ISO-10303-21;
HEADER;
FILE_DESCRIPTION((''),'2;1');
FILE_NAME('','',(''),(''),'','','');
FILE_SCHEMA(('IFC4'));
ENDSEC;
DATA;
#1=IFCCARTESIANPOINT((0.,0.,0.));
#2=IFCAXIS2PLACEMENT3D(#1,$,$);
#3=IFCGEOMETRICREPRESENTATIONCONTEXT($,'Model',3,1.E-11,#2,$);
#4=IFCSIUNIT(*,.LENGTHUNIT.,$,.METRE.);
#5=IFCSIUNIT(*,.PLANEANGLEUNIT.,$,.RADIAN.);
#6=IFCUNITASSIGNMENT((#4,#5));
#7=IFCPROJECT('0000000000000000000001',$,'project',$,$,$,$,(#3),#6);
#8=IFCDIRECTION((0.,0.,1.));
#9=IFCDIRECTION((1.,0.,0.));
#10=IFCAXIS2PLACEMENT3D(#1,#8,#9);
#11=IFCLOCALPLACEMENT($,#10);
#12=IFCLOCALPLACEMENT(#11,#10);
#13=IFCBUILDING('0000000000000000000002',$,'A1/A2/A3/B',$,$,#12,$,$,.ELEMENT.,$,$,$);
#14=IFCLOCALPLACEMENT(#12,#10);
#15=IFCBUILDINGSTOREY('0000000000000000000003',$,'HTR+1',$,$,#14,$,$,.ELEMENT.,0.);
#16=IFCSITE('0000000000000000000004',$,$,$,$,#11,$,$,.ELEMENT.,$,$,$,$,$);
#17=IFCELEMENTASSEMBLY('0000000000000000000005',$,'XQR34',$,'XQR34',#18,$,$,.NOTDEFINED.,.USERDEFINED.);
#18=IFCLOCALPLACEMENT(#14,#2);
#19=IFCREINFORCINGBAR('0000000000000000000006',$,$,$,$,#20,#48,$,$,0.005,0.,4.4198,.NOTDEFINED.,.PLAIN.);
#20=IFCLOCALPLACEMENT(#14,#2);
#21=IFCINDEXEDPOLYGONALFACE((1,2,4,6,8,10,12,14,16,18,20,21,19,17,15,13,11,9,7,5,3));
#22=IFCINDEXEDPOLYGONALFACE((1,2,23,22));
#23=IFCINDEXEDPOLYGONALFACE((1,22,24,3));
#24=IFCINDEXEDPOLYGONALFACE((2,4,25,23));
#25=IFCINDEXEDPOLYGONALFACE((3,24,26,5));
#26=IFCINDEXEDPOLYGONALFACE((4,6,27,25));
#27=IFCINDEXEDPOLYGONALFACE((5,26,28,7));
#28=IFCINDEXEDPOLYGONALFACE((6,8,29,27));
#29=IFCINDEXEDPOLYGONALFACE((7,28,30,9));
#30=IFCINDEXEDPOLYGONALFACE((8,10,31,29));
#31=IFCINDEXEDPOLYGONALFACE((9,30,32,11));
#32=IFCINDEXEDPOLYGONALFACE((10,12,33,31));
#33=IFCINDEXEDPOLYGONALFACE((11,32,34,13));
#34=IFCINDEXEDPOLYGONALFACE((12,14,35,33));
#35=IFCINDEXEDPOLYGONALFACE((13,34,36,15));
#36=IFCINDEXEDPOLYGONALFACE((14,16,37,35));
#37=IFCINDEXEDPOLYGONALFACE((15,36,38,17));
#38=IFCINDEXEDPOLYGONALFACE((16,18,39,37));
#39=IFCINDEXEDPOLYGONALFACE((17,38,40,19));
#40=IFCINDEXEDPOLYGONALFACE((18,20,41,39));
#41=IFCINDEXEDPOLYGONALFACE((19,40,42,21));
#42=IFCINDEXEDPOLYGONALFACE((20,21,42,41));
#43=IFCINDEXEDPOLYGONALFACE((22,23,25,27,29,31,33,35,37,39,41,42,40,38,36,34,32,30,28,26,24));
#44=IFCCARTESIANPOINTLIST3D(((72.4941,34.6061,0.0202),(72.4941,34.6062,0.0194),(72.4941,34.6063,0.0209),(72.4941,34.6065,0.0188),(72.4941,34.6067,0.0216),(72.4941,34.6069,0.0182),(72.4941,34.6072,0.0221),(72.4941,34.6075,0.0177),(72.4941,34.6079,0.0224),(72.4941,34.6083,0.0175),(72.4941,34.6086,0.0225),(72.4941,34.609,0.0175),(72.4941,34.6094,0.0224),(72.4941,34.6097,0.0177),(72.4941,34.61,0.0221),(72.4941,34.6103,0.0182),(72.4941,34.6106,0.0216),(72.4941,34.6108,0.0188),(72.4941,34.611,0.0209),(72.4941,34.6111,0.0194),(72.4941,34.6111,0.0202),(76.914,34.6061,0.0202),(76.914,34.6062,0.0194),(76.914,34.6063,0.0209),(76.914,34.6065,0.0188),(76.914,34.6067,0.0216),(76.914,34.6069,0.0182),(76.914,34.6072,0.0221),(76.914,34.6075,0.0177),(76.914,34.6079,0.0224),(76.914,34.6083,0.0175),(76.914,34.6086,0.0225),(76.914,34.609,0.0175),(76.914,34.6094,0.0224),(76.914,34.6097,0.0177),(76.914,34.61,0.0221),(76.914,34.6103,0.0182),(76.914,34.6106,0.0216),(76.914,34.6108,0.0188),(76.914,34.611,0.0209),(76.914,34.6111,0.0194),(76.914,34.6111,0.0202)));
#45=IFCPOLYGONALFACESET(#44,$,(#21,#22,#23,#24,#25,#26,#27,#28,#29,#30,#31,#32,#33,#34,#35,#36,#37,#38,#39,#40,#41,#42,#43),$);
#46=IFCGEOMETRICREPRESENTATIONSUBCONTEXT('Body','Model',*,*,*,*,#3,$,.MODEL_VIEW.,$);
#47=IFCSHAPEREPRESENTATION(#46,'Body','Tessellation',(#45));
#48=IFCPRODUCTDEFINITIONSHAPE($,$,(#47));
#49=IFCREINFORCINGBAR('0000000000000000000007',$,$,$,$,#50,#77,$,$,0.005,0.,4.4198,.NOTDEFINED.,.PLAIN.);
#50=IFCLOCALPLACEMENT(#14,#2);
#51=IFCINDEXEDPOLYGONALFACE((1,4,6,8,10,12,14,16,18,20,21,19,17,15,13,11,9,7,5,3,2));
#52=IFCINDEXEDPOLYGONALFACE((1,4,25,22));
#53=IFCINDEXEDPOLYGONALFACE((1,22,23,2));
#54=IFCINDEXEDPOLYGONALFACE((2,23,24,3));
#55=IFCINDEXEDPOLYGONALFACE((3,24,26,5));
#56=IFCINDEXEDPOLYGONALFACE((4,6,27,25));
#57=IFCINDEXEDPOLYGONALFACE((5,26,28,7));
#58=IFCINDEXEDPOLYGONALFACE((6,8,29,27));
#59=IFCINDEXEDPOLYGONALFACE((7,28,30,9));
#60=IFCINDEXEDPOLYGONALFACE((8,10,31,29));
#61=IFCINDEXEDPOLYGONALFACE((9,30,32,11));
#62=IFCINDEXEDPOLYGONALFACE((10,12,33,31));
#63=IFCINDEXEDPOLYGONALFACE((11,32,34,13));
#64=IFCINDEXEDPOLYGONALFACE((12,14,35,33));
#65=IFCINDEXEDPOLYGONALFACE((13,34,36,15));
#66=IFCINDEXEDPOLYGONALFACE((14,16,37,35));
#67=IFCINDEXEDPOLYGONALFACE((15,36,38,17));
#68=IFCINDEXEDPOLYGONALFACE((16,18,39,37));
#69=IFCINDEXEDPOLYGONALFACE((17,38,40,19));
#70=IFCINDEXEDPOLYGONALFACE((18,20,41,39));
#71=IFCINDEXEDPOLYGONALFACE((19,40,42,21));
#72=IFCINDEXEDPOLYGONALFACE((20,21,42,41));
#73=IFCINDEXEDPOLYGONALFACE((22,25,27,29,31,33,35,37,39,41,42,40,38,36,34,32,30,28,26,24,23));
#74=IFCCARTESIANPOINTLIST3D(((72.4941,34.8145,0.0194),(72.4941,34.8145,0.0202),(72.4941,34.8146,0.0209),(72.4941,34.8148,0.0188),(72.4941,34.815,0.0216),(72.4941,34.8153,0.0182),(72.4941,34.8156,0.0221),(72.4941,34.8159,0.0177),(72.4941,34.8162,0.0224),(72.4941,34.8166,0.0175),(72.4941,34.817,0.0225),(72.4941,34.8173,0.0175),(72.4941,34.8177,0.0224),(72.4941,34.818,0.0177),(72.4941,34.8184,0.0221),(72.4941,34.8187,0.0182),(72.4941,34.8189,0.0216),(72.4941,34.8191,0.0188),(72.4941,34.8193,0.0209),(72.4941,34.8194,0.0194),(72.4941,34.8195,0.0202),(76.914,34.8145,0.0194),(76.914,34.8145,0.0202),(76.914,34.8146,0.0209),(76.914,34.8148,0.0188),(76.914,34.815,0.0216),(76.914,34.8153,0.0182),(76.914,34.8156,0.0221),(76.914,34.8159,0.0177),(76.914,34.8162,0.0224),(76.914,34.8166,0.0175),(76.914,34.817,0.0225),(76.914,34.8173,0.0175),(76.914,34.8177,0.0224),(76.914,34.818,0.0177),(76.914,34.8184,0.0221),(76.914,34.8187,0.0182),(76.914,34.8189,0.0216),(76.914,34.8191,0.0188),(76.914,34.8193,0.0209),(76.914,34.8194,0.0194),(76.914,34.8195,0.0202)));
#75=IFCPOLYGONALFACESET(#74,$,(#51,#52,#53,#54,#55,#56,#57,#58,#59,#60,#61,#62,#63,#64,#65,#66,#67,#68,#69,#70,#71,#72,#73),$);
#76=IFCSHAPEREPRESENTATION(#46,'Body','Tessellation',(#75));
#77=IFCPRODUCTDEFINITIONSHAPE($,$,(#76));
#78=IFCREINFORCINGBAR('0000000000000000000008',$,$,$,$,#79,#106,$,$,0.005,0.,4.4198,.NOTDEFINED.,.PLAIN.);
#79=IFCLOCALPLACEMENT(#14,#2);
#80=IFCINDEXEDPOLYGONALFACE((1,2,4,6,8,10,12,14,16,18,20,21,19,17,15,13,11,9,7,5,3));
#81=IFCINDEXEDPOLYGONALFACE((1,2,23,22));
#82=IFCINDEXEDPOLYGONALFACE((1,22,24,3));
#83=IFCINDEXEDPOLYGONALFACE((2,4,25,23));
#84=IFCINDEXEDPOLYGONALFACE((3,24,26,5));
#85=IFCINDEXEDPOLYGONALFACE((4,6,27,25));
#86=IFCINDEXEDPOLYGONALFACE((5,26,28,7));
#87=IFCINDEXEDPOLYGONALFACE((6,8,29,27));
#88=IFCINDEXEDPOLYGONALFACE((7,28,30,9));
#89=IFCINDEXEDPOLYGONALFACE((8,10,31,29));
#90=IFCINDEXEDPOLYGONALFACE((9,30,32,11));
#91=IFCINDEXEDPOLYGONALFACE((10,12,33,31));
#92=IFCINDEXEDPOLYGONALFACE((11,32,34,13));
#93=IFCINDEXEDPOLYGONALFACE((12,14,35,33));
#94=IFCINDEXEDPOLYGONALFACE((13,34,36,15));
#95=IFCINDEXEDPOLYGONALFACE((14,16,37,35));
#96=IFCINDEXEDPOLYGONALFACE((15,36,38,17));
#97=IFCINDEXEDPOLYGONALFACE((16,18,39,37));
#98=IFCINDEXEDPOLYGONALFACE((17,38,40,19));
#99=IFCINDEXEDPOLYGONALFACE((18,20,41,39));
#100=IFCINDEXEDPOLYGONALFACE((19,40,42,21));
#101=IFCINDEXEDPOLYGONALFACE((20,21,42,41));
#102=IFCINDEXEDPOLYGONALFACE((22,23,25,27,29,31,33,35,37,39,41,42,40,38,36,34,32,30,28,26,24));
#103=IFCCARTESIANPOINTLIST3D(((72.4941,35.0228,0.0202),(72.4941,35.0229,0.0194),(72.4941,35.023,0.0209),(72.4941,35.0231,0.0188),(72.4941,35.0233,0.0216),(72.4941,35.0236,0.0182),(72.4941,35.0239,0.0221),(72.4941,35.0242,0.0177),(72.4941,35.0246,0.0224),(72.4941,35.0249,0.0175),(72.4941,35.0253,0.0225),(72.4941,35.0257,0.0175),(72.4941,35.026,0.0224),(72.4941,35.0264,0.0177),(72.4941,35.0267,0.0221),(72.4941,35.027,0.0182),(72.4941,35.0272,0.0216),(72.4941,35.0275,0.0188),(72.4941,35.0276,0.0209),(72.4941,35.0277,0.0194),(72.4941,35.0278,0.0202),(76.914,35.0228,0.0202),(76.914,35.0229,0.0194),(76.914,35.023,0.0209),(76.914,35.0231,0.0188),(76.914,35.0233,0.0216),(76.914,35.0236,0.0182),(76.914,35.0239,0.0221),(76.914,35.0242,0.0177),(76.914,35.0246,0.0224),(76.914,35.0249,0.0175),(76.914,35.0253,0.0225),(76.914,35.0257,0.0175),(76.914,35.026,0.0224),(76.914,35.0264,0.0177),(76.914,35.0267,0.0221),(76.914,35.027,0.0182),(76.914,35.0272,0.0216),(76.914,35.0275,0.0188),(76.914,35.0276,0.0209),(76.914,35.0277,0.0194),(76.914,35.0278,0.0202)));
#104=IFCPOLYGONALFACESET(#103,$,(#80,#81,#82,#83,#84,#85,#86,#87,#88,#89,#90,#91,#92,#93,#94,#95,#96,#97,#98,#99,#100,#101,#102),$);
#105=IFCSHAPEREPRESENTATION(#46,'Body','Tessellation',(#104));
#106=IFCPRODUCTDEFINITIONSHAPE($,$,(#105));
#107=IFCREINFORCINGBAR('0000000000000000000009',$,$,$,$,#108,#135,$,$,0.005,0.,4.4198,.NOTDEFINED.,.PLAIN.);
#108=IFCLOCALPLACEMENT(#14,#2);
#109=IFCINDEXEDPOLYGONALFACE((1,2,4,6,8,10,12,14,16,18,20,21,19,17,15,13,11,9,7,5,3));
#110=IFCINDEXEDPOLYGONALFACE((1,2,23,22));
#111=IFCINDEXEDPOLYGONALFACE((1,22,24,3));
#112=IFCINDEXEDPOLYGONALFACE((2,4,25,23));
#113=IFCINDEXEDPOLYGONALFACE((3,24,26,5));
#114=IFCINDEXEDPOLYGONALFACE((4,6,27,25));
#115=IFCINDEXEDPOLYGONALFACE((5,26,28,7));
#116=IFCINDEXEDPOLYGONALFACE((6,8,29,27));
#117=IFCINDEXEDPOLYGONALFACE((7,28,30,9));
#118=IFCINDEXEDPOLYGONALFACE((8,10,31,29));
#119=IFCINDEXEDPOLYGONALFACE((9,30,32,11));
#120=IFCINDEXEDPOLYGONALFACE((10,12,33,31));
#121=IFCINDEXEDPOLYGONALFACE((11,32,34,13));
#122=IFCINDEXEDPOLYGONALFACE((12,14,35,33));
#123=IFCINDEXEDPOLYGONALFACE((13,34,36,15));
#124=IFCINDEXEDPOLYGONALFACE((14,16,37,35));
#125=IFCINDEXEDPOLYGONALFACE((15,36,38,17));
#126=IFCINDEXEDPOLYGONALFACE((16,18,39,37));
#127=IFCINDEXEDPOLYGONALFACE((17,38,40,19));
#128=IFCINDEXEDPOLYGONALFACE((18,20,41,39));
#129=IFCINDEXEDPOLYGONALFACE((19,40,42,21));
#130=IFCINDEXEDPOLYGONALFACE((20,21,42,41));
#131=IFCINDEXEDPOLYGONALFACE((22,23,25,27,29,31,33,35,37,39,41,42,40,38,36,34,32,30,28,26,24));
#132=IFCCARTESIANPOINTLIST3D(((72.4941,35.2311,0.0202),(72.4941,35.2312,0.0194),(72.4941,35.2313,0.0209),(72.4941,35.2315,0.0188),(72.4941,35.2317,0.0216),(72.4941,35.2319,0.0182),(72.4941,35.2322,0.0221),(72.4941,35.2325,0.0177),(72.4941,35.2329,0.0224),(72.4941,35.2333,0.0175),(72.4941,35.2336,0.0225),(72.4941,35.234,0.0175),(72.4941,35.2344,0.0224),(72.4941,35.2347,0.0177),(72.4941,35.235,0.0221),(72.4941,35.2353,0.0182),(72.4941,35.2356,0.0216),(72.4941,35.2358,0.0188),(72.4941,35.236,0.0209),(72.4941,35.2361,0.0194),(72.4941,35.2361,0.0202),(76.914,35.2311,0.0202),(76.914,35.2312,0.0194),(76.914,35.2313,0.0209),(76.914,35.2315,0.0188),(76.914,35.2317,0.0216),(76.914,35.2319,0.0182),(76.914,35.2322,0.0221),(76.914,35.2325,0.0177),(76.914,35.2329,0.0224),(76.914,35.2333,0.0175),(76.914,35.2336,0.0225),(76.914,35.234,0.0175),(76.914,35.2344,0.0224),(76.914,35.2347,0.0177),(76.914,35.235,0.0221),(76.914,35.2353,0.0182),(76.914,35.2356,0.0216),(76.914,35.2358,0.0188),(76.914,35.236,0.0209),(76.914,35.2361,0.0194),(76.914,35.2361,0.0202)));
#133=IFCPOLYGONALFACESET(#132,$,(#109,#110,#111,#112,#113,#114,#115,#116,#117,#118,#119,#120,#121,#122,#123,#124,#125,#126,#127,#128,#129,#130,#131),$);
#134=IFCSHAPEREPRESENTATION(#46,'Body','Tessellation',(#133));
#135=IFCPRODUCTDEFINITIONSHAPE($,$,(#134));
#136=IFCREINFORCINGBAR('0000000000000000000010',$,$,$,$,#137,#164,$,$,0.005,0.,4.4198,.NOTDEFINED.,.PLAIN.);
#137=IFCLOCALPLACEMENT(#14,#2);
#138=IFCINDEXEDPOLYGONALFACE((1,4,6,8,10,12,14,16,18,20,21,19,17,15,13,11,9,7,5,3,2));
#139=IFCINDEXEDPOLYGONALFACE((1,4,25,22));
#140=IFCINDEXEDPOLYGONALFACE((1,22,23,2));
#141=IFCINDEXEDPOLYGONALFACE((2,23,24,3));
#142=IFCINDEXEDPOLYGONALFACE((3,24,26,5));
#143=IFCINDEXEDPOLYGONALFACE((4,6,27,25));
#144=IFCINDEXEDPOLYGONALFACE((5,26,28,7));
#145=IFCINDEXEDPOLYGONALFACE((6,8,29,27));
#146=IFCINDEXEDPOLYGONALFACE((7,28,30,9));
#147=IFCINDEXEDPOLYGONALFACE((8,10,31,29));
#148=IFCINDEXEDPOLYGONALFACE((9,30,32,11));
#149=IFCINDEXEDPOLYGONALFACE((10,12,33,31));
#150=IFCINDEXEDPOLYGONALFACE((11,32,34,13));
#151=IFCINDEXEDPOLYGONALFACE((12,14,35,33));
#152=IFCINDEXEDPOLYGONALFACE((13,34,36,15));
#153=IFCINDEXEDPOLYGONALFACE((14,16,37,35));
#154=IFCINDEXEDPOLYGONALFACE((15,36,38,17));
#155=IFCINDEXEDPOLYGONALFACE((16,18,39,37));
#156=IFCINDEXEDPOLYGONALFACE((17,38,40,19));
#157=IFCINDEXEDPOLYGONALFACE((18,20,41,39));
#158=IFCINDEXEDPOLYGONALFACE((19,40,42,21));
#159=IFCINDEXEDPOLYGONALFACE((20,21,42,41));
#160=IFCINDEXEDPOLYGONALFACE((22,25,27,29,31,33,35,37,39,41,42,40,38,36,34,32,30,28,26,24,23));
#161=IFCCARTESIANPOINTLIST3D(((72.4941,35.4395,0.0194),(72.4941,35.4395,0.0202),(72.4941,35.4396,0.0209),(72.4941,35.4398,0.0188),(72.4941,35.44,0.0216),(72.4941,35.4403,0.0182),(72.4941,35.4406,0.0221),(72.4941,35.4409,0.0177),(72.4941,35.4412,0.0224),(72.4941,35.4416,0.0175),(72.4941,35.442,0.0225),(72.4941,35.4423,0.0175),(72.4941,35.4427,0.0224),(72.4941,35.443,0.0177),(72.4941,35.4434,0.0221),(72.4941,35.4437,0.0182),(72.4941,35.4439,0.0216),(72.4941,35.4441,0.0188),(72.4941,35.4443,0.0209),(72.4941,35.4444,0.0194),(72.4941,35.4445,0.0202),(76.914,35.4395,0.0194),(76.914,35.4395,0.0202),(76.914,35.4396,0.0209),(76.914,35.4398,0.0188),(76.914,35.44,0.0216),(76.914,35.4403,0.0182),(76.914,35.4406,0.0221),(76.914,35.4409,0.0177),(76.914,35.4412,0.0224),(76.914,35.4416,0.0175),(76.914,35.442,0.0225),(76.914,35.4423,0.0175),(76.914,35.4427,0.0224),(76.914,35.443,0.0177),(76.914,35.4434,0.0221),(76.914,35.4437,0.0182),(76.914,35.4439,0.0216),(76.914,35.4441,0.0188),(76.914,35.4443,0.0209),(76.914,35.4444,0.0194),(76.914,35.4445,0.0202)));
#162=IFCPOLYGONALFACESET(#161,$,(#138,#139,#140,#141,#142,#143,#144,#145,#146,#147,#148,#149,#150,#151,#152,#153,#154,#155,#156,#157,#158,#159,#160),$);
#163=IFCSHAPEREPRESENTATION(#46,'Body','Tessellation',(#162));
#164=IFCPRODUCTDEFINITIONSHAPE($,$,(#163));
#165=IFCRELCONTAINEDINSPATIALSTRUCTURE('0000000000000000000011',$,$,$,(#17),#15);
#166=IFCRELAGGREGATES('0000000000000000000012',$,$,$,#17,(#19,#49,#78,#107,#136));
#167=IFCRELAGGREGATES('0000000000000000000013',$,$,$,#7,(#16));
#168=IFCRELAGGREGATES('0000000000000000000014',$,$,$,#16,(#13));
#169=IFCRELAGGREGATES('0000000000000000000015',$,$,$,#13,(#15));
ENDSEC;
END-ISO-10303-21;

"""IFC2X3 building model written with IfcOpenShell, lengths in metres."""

from ifc_helpers import new_model, entity, si_unit, origin, origin_with_axes, place, context, subcontext, project, spatial, shape, element, aggregate, save


model = new_model("IFC2X3")

# Units and contexts
model_context = context("Model", 3, precision=1e-11, world=origin())
body_context = subcontext(model_context, "Body", "Model", "MODEL_VIEW")
ifc_project = project(units=[si_unit("LENGTHUNIT", "METRE"), si_unit("PLANEANGLEUNIT", "RADIAN")], contexts=[model_context])

# Site, building, storey
site_placement = place(None, origin_with_axes())
site = spatial("IfcSite", under=ifc_project, at=site_placement, CompositionType="ELEMENT")
building_placement = place(site_placement, origin_with_axes())
building = spatial("IfcBuilding", under=site, at=building_placement, Name="A1/A2/A3/B", CompositionType="ELEMENT")
storey_placement = place(building_placement, origin_with_axes())
storey = spatial("IfcBuildingStorey", under=building, at=storey_placement, Name="HTR+1", CompositionType="ELEMENT", Elevation=0.0)

# Element assembly, reinforcing bars
assembly_1_placement = place(storey_placement, origin_with_axes())
assembly_1 = element("IfcElementAssembly", 1, at=assembly_1_placement, inside=storey, Name="XQR34", ObjectType="XQR34", AssemblyPlace="NOTDEFINED", PredefinedType="USERDEFINED")
reinforcing_bar_1_placement = place(assembly_1_placement, origin_with_axes())
reinforcing_bar_1 = element("IfcReinforcingBar", 2, at=reinforcing_bar_1_placement, BarLength=4.4198, BarRole="NOTDEFINED", BarSurface="PLAIN", CrossSectionArea=0.0, NominalDiameter=0.005, shapes=[
    shape(body_context, "Body", "AdvancedSweptSolid", [entity("IfcSweptDiskSolid", entity("IfcPolyline", [entity("IfcCartesianPoint", [72.4941, 34.6086, 0.02]), entity("IfcCartesianPoint", [76.914, 34.6086, 0.02])]), 0.0025, None, 0.0, 4.4198)]),
    shape(body_context, "Body", "AdvancedSweptSolid", [entity("IfcSweptDiskSolid", entity("IfcPolyline", [entity("IfcCartesianPoint", [72.4941, 34.6086, 0.02]), entity("IfcCartesianPoint", [76.914, 34.6086, 0.02])]), 0.0025, None, 0.0, 4.4198)]),
])
reinforcing_bar_2_placement = place(assembly_1_placement, origin_with_axes())
reinforcing_bar_2 = element("IfcReinforcingBar", 3, at=reinforcing_bar_2_placement, BarLength=4.4198, BarRole="NOTDEFINED", BarSurface="PLAIN", CrossSectionArea=0.0, NominalDiameter=0.005, shapes=[
    shape(body_context, "Body", "AdvancedSweptSolid", [entity("IfcSweptDiskSolid", entity("IfcPolyline", [entity("IfcCartesianPoint", [72.4941, 34.817, 0.02]), entity("IfcCartesianPoint", [76.914, 34.817, 0.02])]), 0.0025, None, 0.0, 4.4198)]),
    shape(body_context, "Body", "AdvancedSweptSolid", [entity("IfcSweptDiskSolid", entity("IfcPolyline", [entity("IfcCartesianPoint", [72.4941, 34.817, 0.02]), entity("IfcCartesianPoint", [76.914, 34.817, 0.02])]), 0.0025, None, 0.0, 4.4198)]),
])
reinforcing_bar_3_placement = place(assembly_1_placement, origin_with_axes())
reinforcing_bar_3 = element("IfcReinforcingBar", 4, at=reinforcing_bar_3_placement, BarLength=4.4198, BarRole="NOTDEFINED", BarSurface="PLAIN", CrossSectionArea=0.0, NominalDiameter=0.005, shapes=[
    shape(body_context, "Body", "AdvancedSweptSolid", [entity("IfcSweptDiskSolid", entity("IfcPolyline", [entity("IfcCartesianPoint", [72.4941, 35.0253, 0.02]), entity("IfcCartesianPoint", [76.914, 35.0253, 0.02])]), 0.0025, None, 0.0, 4.4198)]),
    shape(body_context, "Body", "AdvancedSweptSolid", [entity("IfcSweptDiskSolid", entity("IfcPolyline", [entity("IfcCartesianPoint", [72.4941, 35.0253, 0.02]), entity("IfcCartesianPoint", [76.914, 35.0253, 0.02])]), 0.0025, None, 0.0, 4.4198)]),
])
reinforcing_bar_4_placement = place(assembly_1_placement, origin_with_axes())
reinforcing_bar_4 = element("IfcReinforcingBar", 5, at=reinforcing_bar_4_placement, BarLength=4.4198, BarRole="NOTDEFINED", BarSurface="PLAIN", CrossSectionArea=0.0, NominalDiameter=0.005, shapes=[
    shape(body_context, "Body", "AdvancedSweptSolid", [entity("IfcSweptDiskSolid", entity("IfcPolyline", [entity("IfcCartesianPoint", [72.4941, 35.2336, 0.02]), entity("IfcCartesianPoint", [76.914, 35.2336, 0.02])]), 0.0025, None, 0.0, 4.4198)]),
    shape(body_context, "Body", "AdvancedSweptSolid", [entity("IfcSweptDiskSolid", entity("IfcPolyline", [entity("IfcCartesianPoint", [72.4941, 35.2336, 0.02]), entity("IfcCartesianPoint", [76.914, 35.2336, 0.02])]), 0.0025, None, 0.0, 4.4198)]),
])
reinforcing_bar_5_placement = place(assembly_1_placement, origin_with_axes())
reinforcing_bar_5 = element("IfcReinforcingBar", 6, at=reinforcing_bar_5_placement, BarLength=4.4198, BarRole="NOTDEFINED", BarSurface="PLAIN", CrossSectionArea=0.0, NominalDiameter=0.005, shapes=[
    shape(body_context, "Body", "AdvancedSweptSolid", [entity("IfcSweptDiskSolid", entity("IfcPolyline", [entity("IfcCartesianPoint", [72.4941, 35.442, 0.02]), entity("IfcCartesianPoint", [76.914, 35.442, 0.02])]), 0.0025, None, 0.0, 4.4198)]),
    shape(body_context, "Body", "AdvancedSweptSolid", [entity("IfcSweptDiskSolid", entity("IfcPolyline", [entity("IfcCartesianPoint", [72.4941, 35.442, 0.02]), entity("IfcCartesianPoint", [76.914, 35.442, 0.02])]), 0.0025, None, 0.0, 4.4198)]),
])
aggregate(assembly_1, [reinforcing_bar_1, reinforcing_bar_2, reinforcing_bar_3, reinforcing_bar_4, reinforcing_bar_5])

save(model, "model.ifc")
